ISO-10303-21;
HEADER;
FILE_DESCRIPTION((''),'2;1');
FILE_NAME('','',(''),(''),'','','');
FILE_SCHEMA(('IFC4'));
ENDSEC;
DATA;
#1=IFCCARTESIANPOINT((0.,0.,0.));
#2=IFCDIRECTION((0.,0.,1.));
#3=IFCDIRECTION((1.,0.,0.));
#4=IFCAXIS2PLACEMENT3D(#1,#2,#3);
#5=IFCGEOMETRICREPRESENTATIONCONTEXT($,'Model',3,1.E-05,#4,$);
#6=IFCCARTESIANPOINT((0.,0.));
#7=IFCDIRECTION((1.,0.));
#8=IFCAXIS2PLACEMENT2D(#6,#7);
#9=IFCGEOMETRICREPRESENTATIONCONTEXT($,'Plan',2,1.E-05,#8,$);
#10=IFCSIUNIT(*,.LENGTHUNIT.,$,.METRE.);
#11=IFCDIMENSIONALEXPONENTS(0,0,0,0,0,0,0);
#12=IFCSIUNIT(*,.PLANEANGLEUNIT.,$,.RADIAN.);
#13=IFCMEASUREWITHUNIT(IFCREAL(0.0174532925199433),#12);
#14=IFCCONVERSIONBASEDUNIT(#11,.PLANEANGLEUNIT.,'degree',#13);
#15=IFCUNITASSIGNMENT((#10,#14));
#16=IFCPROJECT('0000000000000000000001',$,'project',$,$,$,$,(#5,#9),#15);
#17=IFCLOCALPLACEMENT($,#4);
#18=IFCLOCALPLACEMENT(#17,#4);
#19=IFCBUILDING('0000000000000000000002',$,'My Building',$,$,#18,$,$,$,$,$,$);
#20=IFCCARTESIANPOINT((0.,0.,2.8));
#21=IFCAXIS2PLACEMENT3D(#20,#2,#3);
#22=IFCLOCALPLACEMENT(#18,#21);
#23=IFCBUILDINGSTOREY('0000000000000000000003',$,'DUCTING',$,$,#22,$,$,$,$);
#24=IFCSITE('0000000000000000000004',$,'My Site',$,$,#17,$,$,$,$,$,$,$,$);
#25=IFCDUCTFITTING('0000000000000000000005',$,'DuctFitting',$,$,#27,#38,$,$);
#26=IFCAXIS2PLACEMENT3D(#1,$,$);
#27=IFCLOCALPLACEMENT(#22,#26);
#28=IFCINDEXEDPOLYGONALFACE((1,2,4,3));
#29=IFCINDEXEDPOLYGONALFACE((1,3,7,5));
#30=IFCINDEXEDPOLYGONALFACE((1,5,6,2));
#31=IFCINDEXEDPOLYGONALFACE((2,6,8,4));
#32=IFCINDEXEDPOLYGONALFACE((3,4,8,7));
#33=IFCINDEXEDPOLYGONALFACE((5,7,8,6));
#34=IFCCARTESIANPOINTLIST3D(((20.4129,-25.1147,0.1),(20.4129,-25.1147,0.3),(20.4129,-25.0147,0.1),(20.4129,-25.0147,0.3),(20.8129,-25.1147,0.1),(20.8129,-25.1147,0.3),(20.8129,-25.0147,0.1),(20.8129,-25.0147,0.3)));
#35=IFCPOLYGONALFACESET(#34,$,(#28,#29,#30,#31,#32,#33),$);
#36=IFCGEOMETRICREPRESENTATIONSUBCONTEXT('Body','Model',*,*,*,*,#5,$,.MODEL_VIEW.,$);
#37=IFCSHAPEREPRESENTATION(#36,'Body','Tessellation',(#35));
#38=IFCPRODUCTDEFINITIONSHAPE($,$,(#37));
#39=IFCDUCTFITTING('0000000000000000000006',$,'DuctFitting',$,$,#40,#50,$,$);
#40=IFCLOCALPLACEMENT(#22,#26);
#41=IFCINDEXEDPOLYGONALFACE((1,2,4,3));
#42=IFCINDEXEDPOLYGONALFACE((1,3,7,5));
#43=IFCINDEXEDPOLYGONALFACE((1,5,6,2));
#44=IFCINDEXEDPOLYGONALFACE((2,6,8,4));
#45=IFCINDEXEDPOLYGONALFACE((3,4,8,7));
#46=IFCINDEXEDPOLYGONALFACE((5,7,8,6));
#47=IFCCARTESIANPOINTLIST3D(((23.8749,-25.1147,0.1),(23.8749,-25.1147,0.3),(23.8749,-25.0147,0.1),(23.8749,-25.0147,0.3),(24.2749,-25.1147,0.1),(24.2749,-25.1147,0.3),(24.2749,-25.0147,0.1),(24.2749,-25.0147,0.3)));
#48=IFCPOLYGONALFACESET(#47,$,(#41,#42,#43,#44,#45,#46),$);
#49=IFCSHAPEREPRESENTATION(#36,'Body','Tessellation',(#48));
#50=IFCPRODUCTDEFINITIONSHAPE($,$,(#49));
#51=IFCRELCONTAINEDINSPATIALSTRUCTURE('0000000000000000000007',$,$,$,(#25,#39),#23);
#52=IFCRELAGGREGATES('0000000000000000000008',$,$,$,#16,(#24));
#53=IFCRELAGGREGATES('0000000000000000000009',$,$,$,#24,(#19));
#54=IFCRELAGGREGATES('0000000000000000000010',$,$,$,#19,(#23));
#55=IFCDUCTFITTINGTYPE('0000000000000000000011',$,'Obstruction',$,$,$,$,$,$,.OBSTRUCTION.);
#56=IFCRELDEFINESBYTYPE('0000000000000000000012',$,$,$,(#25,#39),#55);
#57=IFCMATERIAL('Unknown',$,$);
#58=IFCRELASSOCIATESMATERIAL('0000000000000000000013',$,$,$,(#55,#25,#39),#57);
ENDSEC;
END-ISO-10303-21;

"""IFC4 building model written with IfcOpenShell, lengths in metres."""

from ifc_helpers import new_model, entity, si_unit, converted_unit, frame, origin_with_axes, origin_2d_with_axis, place, context, subcontext, project, spatial, rectangle, extrude, material, material_profile, profile_set, profile_usage, type_object, element, save


model = new_model("IFC4")

# Units and contexts
model_context = context("Model", 3, precision=1e-05, world=origin_with_axes())
plan_context = context("Plan", 2, precision=1e-05, world=origin_2d_with_axis())
body_context = subcontext(model_context, "Body", "Model", "MODEL_VIEW")
ifc_project = project(units=[si_unit("LENGTHUNIT", "METRE"), converted_unit("PLANEANGLEUNIT", "degree", entity("IfcReal", 0.0174532925199433), si_unit("PLANEANGLEUNIT", "RADIAN"), dimensions=[0, 0, 0, 0, 0, 0, 0])], contexts=[model_context, plan_context])

# Site, building, storey
site_placement = place(None, origin_with_axes())
site = spatial("IfcSite", under=ifc_project, at=site_placement, Name="My Site")
building_placement = place(site_placement, origin_with_axes())
building = spatial("IfcBuilding", under=site, at=building_placement, Name="My Building")
storey_placement = place(building_placement, frame((0.0, 0.0, 2.8), z_axis=(0.0, 0.0, 1.0), x_axis=(1.0, 0.0, 0.0)))
storey = spatial("IfcBuildingStorey", under=building, at=storey_placement, Name="DUCTING")

# Shared definitions
ifc_material = material(Name="Unknown")

# Duct fittings
ifc_material_profile_1 = material_profile(ifc_material, rectangle(XDim=0.4, YDim=0.2))
ifc_profile_set_1 = profile_set([ifc_material_profile_1])
duct_fitting_type_1 = type_object("IfcDuctFittingType", Name="Obstruction", PredefinedType="OBSTRUCTION", material=ifc_profile_set_1)
ifc_profile_usage_1 = profile_usage(ifc_profile_set_1, cardinal=5)
duct_fitting_1_placement = place(storey_placement, frame((20.6129, -25.0147, 0.2), z_axis=(0.0, -1.0, 0.0), x_axis=(1.0, 0.0, 0.0)))
element("IfcDuctFitting", 1, at=duct_fitting_1_placement, inside=storey, type_object=duct_fitting_type_1, material=ifc_profile_usage_1, Name="DuctFitting", context=body_context, shape_type="SweptSolid", body=[
    extrude(rectangle(XDim=0.4, YDim=0.2), origin_with_axes(), (0.0, 0.0, 1.0), 0.1),
])
ifc_profile_usage_2 = profile_usage(ifc_profile_set_1, cardinal=5)
duct_fitting_2_placement = place(storey_placement, frame((24.0749, -25.0147, 0.2), z_axis=(0.0, -1.0, 0.0), x_axis=(1.0, 0.0, 0.0)))
element("IfcDuctFitting", 2, at=duct_fitting_2_placement, inside=storey, type_object=duct_fitting_type_1, material=ifc_profile_usage_2, Name="DuctFitting", context=body_context, shape_type="SweptSolid", body=[
    extrude(rectangle(XDim=0.4, YDim=0.2), origin_with_axes(), (0.0, 0.0, 1.0), 0.1),
])

save(model, "model.ifc")
